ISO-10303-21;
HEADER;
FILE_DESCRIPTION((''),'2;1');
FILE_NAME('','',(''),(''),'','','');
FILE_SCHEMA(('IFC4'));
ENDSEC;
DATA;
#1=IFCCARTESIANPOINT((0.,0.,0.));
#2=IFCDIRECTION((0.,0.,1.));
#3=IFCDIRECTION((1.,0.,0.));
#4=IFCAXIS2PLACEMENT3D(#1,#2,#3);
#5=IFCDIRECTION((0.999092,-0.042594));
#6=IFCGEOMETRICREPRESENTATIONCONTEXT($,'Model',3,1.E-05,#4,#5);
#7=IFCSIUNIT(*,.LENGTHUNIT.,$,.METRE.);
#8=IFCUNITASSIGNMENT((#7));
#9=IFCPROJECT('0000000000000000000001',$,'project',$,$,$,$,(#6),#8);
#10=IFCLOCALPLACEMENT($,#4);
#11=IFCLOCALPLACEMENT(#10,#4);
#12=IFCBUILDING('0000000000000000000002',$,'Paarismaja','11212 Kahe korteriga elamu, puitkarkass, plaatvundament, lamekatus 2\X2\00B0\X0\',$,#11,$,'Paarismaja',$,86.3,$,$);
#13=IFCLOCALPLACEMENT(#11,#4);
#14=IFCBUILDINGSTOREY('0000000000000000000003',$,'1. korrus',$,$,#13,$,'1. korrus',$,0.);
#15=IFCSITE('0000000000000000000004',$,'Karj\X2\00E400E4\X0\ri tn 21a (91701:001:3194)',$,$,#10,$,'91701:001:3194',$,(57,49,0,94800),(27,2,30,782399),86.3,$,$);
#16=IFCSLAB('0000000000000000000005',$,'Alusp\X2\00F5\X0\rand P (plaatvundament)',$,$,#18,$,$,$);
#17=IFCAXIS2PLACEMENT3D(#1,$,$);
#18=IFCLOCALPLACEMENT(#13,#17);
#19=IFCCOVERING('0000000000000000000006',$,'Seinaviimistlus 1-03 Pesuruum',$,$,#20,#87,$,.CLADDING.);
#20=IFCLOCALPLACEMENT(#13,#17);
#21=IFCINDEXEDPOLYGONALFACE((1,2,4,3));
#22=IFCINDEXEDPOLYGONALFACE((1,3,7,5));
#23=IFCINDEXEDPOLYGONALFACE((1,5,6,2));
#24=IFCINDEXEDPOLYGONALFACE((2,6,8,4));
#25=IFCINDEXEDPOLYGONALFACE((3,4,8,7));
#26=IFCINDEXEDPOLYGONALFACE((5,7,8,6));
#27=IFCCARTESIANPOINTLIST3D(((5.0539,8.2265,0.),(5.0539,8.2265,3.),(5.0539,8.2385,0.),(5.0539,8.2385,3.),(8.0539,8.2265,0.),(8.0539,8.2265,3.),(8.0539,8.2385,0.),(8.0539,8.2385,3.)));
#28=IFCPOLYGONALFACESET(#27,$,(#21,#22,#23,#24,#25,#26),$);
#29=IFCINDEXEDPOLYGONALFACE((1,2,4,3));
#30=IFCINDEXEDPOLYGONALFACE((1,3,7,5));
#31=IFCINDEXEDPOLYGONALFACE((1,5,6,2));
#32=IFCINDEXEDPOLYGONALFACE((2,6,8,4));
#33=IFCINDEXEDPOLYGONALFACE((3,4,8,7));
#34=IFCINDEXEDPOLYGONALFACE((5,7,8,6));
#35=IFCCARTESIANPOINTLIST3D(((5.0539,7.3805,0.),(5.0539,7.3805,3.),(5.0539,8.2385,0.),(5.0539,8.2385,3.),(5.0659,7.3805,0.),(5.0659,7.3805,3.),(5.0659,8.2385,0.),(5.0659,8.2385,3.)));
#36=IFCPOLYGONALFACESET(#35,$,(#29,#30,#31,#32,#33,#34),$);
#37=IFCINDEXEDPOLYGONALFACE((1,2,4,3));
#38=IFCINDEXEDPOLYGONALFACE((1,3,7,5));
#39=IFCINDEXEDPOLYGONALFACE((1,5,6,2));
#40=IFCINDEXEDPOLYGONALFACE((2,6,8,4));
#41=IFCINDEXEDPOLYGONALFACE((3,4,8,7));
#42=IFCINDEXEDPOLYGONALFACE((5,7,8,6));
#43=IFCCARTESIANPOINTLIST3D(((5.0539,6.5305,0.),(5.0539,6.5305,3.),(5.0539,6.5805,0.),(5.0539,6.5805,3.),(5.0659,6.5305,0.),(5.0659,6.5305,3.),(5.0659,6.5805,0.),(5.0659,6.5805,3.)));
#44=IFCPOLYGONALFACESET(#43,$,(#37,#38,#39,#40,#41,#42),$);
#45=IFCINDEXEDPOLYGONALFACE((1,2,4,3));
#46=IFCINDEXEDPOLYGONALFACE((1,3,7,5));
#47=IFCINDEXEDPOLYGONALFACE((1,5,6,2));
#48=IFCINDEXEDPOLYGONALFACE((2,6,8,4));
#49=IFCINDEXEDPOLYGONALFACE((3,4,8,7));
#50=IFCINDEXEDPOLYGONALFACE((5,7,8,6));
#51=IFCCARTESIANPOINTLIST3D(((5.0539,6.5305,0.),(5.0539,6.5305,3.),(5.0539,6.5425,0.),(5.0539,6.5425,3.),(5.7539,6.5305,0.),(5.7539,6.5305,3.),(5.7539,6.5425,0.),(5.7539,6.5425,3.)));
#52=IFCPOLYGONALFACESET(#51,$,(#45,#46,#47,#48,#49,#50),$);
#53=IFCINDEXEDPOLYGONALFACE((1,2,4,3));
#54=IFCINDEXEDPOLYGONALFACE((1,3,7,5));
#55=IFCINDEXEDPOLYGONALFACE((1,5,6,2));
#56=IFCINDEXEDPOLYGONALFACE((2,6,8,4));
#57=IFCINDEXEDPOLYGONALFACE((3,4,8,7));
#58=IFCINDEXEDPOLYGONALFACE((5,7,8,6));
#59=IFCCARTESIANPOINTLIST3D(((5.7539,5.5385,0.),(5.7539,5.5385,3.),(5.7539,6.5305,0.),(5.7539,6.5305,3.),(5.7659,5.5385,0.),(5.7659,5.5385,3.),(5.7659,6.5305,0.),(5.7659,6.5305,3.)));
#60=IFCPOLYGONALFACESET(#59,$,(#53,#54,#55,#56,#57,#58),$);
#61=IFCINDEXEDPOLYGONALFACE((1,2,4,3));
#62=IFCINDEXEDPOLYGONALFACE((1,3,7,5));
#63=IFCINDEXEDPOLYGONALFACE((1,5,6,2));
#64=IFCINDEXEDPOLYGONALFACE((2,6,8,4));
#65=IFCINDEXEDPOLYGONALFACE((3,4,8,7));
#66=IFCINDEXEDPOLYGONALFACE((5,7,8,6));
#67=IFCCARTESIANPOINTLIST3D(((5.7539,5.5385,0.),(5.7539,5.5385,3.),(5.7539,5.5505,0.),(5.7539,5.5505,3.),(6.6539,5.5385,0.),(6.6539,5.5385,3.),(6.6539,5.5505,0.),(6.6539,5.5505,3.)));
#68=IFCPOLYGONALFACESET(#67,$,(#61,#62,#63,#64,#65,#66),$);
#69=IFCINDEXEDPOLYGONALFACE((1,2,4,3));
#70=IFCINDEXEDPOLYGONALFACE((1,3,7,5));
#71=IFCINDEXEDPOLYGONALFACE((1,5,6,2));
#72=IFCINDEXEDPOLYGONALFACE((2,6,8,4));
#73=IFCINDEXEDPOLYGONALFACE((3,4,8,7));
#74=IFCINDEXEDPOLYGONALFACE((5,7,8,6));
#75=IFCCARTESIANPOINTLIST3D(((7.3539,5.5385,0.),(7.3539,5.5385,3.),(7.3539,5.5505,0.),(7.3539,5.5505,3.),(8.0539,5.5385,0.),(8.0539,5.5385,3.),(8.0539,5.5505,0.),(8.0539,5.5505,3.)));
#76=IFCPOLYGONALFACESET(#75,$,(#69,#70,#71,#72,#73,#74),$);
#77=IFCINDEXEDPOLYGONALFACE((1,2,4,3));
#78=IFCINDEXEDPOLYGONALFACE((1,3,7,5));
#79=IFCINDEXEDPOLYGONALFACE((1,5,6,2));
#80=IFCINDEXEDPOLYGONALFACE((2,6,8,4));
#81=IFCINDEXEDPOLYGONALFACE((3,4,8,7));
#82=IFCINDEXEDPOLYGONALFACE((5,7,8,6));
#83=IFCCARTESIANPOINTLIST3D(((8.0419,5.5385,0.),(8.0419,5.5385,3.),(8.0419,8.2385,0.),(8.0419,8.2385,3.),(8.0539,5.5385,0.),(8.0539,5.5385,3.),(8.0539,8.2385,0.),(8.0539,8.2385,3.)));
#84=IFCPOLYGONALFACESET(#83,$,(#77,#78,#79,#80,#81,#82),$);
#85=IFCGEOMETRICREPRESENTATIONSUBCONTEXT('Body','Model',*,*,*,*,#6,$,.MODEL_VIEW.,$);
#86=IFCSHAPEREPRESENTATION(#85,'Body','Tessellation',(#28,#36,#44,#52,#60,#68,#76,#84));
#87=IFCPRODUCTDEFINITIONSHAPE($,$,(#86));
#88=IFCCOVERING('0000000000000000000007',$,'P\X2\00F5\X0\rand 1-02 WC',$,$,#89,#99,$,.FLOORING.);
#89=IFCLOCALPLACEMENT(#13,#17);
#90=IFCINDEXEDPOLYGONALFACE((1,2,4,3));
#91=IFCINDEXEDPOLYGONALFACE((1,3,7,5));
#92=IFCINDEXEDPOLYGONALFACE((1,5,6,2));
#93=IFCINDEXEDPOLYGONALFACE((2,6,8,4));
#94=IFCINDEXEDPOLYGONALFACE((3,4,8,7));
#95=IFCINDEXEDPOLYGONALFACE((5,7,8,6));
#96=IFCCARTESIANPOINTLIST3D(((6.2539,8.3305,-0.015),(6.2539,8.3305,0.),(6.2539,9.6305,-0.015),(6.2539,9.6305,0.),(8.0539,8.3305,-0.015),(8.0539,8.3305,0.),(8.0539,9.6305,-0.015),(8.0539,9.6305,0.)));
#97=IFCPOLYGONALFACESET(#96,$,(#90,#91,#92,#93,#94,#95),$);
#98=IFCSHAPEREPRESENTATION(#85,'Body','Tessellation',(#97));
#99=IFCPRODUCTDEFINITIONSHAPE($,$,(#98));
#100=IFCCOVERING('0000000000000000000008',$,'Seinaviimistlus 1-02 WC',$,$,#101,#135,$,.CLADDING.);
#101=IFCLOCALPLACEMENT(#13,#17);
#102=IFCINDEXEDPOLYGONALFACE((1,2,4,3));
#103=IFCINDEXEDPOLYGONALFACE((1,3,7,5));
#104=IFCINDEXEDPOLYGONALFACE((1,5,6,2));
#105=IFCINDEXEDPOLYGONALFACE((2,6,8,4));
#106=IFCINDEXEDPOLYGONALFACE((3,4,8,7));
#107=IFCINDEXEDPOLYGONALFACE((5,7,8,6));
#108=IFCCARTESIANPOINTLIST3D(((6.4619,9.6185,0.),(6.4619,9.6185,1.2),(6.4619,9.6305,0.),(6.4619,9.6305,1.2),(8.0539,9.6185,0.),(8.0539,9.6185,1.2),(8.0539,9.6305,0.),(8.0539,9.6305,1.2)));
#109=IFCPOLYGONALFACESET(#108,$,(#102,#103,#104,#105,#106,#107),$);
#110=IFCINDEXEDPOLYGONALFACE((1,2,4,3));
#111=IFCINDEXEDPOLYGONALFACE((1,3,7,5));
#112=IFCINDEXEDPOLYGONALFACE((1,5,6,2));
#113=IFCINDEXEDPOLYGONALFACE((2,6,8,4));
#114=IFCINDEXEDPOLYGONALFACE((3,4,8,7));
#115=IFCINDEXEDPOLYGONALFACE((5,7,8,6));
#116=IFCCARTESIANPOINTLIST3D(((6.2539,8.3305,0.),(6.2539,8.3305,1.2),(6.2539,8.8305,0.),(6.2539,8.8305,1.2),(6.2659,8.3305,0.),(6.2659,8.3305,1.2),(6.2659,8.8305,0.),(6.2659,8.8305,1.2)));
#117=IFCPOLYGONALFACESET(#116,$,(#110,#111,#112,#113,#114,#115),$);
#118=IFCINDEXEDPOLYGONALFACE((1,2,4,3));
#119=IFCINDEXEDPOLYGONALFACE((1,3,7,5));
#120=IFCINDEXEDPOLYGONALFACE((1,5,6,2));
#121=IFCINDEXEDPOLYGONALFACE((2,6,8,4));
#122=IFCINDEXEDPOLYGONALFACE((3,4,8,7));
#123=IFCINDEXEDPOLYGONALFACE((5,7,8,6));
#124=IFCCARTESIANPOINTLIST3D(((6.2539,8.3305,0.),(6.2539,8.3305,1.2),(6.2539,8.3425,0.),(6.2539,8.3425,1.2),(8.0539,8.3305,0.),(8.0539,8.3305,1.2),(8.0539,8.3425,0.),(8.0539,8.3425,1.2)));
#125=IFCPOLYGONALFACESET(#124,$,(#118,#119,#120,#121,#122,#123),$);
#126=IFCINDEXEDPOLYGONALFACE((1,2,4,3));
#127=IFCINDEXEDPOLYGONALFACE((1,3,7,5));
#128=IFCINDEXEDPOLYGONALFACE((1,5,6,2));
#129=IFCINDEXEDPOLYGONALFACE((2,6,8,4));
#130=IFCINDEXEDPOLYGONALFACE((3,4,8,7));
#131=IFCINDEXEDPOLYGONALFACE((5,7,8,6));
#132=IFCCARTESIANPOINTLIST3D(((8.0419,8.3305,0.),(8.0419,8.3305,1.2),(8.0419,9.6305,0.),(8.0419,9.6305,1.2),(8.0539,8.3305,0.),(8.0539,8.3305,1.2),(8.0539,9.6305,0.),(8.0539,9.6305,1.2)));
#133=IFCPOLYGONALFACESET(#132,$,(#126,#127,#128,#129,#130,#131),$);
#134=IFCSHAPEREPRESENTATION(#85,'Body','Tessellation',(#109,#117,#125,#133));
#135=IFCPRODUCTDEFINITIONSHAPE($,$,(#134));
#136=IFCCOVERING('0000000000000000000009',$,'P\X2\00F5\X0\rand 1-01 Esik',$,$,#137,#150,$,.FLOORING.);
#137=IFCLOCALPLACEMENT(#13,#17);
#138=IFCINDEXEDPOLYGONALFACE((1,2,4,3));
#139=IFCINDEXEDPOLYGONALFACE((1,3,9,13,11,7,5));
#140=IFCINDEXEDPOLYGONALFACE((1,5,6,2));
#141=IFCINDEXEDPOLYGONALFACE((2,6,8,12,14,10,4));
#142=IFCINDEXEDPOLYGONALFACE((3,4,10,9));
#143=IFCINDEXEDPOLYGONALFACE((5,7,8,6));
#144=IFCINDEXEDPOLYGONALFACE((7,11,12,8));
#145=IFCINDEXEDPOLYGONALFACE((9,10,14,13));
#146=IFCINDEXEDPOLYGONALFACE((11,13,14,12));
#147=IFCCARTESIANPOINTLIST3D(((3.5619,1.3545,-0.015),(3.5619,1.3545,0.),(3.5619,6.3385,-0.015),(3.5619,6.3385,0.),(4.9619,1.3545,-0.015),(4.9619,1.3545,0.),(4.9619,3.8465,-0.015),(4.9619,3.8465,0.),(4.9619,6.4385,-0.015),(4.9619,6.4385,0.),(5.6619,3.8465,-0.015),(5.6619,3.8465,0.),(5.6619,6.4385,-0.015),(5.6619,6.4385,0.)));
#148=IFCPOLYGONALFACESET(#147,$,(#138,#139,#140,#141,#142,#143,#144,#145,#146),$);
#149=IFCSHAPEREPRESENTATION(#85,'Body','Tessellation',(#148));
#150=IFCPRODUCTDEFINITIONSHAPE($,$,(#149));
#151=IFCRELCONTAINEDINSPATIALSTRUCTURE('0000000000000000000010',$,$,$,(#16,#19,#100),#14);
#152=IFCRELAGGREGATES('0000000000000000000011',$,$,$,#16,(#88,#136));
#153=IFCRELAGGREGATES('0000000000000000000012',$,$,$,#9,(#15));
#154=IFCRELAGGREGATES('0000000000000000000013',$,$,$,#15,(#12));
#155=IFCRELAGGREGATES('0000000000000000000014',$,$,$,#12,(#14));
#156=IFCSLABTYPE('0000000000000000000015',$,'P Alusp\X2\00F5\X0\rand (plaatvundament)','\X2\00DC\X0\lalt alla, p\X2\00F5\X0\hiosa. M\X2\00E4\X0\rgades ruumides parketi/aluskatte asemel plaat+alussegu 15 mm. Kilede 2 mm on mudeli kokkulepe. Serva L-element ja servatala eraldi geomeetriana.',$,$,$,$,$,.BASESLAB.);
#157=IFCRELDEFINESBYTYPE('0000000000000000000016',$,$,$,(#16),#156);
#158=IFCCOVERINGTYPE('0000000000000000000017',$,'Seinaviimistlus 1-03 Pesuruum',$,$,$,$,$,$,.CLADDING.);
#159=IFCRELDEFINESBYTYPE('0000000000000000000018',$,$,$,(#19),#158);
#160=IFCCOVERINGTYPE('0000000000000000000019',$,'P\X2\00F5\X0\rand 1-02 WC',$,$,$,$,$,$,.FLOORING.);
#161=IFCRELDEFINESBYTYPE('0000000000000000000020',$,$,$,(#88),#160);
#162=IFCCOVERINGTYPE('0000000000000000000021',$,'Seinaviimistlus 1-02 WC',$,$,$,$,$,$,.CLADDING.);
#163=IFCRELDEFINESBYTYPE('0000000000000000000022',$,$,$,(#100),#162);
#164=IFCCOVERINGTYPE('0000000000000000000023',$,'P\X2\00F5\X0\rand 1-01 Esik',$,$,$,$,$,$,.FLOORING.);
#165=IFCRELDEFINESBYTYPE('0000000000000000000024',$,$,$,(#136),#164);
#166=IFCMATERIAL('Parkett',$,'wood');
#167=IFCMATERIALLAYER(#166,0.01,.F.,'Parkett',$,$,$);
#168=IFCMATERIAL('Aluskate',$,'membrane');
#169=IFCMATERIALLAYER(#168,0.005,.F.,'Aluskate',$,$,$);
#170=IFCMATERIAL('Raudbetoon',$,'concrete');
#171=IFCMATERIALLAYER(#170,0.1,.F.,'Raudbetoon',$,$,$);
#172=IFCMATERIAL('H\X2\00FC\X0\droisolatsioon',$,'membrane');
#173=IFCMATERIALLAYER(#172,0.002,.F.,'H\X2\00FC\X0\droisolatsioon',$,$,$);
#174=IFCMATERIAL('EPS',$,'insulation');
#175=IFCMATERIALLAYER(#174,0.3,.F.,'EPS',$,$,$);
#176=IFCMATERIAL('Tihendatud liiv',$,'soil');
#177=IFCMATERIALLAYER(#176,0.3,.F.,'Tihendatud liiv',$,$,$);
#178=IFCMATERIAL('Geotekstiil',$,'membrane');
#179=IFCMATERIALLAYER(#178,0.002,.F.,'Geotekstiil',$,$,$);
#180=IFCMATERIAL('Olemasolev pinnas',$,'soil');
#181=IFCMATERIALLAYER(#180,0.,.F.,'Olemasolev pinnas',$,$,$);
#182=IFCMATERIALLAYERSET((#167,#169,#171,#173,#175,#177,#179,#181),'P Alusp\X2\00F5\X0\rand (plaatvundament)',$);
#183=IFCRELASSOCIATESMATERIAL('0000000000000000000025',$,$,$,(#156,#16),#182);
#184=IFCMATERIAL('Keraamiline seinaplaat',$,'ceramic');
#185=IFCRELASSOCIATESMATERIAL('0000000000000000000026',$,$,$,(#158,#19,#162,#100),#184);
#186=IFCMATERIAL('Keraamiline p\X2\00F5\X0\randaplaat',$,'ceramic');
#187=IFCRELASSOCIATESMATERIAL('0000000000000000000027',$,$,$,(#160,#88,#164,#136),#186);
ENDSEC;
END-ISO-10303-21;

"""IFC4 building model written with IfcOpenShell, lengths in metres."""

from ifc_helpers import new_model, si_unit, direction, frame, origin_with_axes, place, context, subcontext, project, spatial, indexed_curve, outline, extrude, material, layer, layer_set, layer_usage, type_object, element, aggregate, save


model = new_model("IFC4")

# Units and contexts
model_context = context("Model", 3, precision=1e-05, world=origin_with_axes(), true_north=direction((0.999092, -0.042594)))
body_context = subcontext(model_context, "Body", "Model", "MODEL_VIEW")
ifc_project = project(units=[si_unit("LENGTHUNIT", "METRE")], contexts=[model_context])

# Site, building, storey
site_placement = place(None, origin_with_axes())
site = spatial("IfcSite", under=ifc_project, at=site_placement, Name="Karjääri tn 21a (91701:001:3194)", LongName="91701:001:3194", RefLatitude=(57, 49, 0, 94800), RefLongitude=(27, 2, 30, 782399), RefElevation=86.3)
building_placement = place(site_placement, origin_with_axes())
building = spatial("IfcBuilding", under=site, at=building_placement, Name="Paarismaja", Description="11212 Kahe korteriga elamu, puitkarkass, plaatvundament, lamekatus 2°", LongName="Paarismaja", ElevationOfRefHeight=86.3)
storey_placement = place(building_placement, origin_with_axes())
storey = spatial("IfcBuildingStorey", under=building, at=storey_placement, Name="1. korrus", LongName="1. korrus", Elevation=0.0)

# Slab
ifc_material_1 = material(Name="Parkett", Category="wood")
ifc_layer_1 = layer(ifc_material_1, 0.01, ventilated=False, Name="Parkett")
ifc_material_2 = material(Name="Aluskate", Category="membrane")
ifc_layer_2 = layer(ifc_material_2, 0.005, ventilated=False, Name="Aluskate")
ifc_material_3 = material(Name="Raudbetoon", Category="concrete")
ifc_layer_3 = layer(ifc_material_3, 0.1, ventilated=False, Name="Raudbetoon")
ifc_material_4 = material(Name="Hüdroisolatsioon", Category="membrane")
ifc_layer_4 = layer(ifc_material_4, 0.002, ventilated=False, Name="Hüdroisolatsioon")
ifc_material_5 = material(Name="EPS", Category="insulation")
ifc_layer_5 = layer(ifc_material_5, 0.3, ventilated=False, Name="EPS")
ifc_material_6 = material(Name="Tihendatud liiv", Category="soil")
ifc_layer_6 = layer(ifc_material_6, 0.3, ventilated=False, Name="Tihendatud liiv")
ifc_material_7 = material(Name="Geotekstiil", Category="membrane")
ifc_layer_7 = layer(ifc_material_7, 0.002, ventilated=False, Name="Geotekstiil")
ifc_material_8 = material(Name="Olemasolev pinnas", Category="soil")
ifc_layer_8 = layer(ifc_material_8, 0.0, ventilated=False, Name="Olemasolev pinnas")
ifc_layer_set = layer_set([ifc_layer_1, ifc_layer_2, ifc_layer_3, ifc_layer_4, ifc_layer_5, ifc_layer_6, ifc_layer_7, ifc_layer_8], Name="P Aluspõrand (plaatvundament)")
ifc_layer_usage = layer_usage(ifc_layer_set, "AXIS3", "NEGATIVE", 0.0)
slab_type_1 = type_object("IfcSlabType", Name="P Aluspõrand (plaatvundament)", Description="Ülalt alla, põhiosa. Märgades ruumides parketi/aluskatte asemel plaat+alussegu 15 mm. Kilede 2 mm on mudeli kokkulepe. Serva L-element ja servatala eraldi geomeetriana.", PredefinedType="BASESLAB", material=ifc_layer_set)
slab_1_placement = place(storey_placement, origin_with_axes())
slab_1 = element("IfcSlab", 1, at=slab_1_placement, inside=storey, type_object=slab_type_1, material=ifc_layer_usage, Name="Aluspõrand P (plaatvundament)")
ifc_material_9 = material(Name="Keraamiline põrandaplaat", Category="ceramic")

# Coverings
ifc_material_10 = material(Name="Keraamiline seinaplaat", Category="ceramic")
covering_type_1 = type_object("IfcCoveringType", Name="Seinaviimistlus 1-03 Pesuruum", PredefinedType="CLADDING", material=ifc_material_10)
covering_1_placement = place(storey_placement, origin_with_axes())
element("IfcCovering", 2, at=covering_1_placement, inside=storey, type_object=covering_type_1, material=ifc_material_10, Name="Seinaviimistlus 1-03 Pesuruum", PredefinedType="CLADDING", context=body_context, shape_type="SweptSolid", body=[
    extrude(outline(indexed_curve([(8.0539, 8.2265), (5.0539, 8.2265), (5.0539, 8.2385), (8.0539, 8.2385), (8.0539, 8.2265)], self_intersect=False)), origin_with_axes(), (0.0, 0.0, 1.0), 3.0),
    extrude(outline(indexed_curve([(5.0539, 8.2385), (5.0659, 8.2385), (5.0659, 7.3805), (5.0539, 7.3805), (5.0539, 8.2385)], self_intersect=False)), origin_with_axes(), (0.0, 0.0, 1.0), 3.0),
    extrude(outline(indexed_curve([(5.0659, 6.5305), (5.0539, 6.5305), (5.0539, 6.5805), (5.0659, 6.5805), (5.0659, 6.5305)], self_intersect=False)), origin_with_axes(), (0.0, 0.0, 1.0), 3.0),
    extrude(outline(indexed_curve([(5.0539, 6.5425), (5.7539, 6.5425), (5.7539, 6.5305), (5.0539, 6.5305), (5.0539, 6.5425)], self_intersect=False)), origin_with_axes(), (0.0, 0.0, 1.0), 3.0),
    extrude(outline(indexed_curve([(5.7659, 6.5305), (5.7659, 5.5385), (5.7539, 5.5385), (5.7539, 6.5305), (5.7659, 6.5305)], self_intersect=False)), origin_with_axes(), (0.0, 0.0, 1.0), 3.0),
    extrude(outline(indexed_curve([(5.7539, 5.5385), (5.7539, 5.5505), (6.6539, 5.5505), (6.6539, 5.5385), (5.7539, 5.5385)], self_intersect=False)), origin_with_axes(), (0.0, 0.0, 1.0), 3.0),
    extrude(outline(indexed_curve([(8.0539, 5.5505), (8.0539, 5.5385), (7.3539, 5.5385), (7.3539, 5.5505), (8.0539, 5.5505)], self_intersect=False)), origin_with_axes(), (0.0, 0.0, 1.0), 3.0),
    extrude(outline(indexed_curve([(8.0419, 5.5385), (8.0419, 8.2385), (8.0539, 8.2385), (8.0539, 5.5385), (8.0419, 5.5385)], self_intersect=False)), origin_with_axes(), (0.0, 0.0, 1.0), 3.0),
])
covering_type_2 = type_object("IfcCoveringType", Name="Põrand 1-02 WC", PredefinedType="FLOORING", material=ifc_material_9)
covering_2_placement = place(slab_1_placement, origin_with_axes())
covering_2 = element("IfcCovering", 3, at=covering_2_placement, type_object=covering_type_2, material=ifc_material_9, Name="Põrand 1-02 WC", PredefinedType="FLOORING", context=body_context, shape_type="SweptSolid", body=[
    extrude(outline(indexed_curve([(8.0539, 9.6305), (8.0539, 8.3305), (6.2539, 8.3305), (6.2539, 9.6305), (8.0539, 9.6305)], self_intersect=False)), frame((0.0, 0.0, -0.015), z_axis=(0.0, 0.0, 1.0), x_axis=(1.0, 0.0, 0.0)), (0.0, 0.0, 1.0), 0.015),
])
covering_type_3 = type_object("IfcCoveringType", Name="Seinaviimistlus 1-02 WC", PredefinedType="CLADDING", material=ifc_material_10)
covering_3_placement = place(storey_placement, origin_with_axes())
element("IfcCovering", 4, at=covering_3_placement, inside=storey, type_object=covering_type_3, material=ifc_material_10, Name="Seinaviimistlus 1-02 WC", PredefinedType="CLADDING", context=body_context, shape_type="SweptSolid", body=[
    extrude(outline(indexed_curve([(8.0539, 9.6305), (8.0539, 9.6185), (6.4619, 9.6185), (6.4619, 9.6305), (8.0539, 9.6305)], self_intersect=False)), origin_with_axes(), (0.0, 0.0, 1.0), 1.2),
    extrude(outline(indexed_curve([(6.2659, 8.3305), (6.2539, 8.3305), (6.2539, 8.8305), (6.2659, 8.8305), (6.2659, 8.3305)], self_intersect=False)), origin_with_axes(), (0.0, 0.0, 1.0), 1.2),
    extrude(outline(indexed_curve([(6.2539, 8.3425), (8.0539, 8.3425), (8.0539, 8.3305), (6.2539, 8.3305), (6.2539, 8.3425)], self_intersect=False)), origin_with_axes(), (0.0, 0.0, 1.0), 1.2),
    extrude(outline(indexed_curve([(8.0419, 8.3305), (8.0419, 9.6305), (8.0539, 9.6305), (8.0539, 8.3305), (8.0419, 8.3305)], self_intersect=False)), origin_with_axes(), (0.0, 0.0, 1.0), 1.2),
])
covering_type_4 = type_object("IfcCoveringType", Name="Põrand 1-01 Esik", PredefinedType="FLOORING", material=ifc_material_9)
covering_4_placement = place(slab_1_placement, origin_with_axes())
covering_4 = element("IfcCovering", 5, at=covering_4_placement, type_object=covering_type_4, material=ifc_material_9, Name="Põrand 1-01 Esik", PredefinedType="FLOORING", context=body_context, shape_type="SweptSolid", body=[
    extrude(outline(indexed_curve([(5.6619, 3.8465), (4.9619, 3.8465), (4.9619, 1.3545), (3.5619, 1.3545), (3.5619, 6.3385), (4.9619, 6.4385), (5.6619, 6.4385), (5.6619, 3.8465)], self_intersect=False)), frame((0.0, 0.0, -0.015), z_axis=(0.0, 0.0, 1.0), x_axis=(1.0, 0.0, 0.0)), (0.0, 0.0, 1.0), 0.015),
])
aggregate(slab_1, [covering_2, covering_4])

save(model, "model.ifc")
